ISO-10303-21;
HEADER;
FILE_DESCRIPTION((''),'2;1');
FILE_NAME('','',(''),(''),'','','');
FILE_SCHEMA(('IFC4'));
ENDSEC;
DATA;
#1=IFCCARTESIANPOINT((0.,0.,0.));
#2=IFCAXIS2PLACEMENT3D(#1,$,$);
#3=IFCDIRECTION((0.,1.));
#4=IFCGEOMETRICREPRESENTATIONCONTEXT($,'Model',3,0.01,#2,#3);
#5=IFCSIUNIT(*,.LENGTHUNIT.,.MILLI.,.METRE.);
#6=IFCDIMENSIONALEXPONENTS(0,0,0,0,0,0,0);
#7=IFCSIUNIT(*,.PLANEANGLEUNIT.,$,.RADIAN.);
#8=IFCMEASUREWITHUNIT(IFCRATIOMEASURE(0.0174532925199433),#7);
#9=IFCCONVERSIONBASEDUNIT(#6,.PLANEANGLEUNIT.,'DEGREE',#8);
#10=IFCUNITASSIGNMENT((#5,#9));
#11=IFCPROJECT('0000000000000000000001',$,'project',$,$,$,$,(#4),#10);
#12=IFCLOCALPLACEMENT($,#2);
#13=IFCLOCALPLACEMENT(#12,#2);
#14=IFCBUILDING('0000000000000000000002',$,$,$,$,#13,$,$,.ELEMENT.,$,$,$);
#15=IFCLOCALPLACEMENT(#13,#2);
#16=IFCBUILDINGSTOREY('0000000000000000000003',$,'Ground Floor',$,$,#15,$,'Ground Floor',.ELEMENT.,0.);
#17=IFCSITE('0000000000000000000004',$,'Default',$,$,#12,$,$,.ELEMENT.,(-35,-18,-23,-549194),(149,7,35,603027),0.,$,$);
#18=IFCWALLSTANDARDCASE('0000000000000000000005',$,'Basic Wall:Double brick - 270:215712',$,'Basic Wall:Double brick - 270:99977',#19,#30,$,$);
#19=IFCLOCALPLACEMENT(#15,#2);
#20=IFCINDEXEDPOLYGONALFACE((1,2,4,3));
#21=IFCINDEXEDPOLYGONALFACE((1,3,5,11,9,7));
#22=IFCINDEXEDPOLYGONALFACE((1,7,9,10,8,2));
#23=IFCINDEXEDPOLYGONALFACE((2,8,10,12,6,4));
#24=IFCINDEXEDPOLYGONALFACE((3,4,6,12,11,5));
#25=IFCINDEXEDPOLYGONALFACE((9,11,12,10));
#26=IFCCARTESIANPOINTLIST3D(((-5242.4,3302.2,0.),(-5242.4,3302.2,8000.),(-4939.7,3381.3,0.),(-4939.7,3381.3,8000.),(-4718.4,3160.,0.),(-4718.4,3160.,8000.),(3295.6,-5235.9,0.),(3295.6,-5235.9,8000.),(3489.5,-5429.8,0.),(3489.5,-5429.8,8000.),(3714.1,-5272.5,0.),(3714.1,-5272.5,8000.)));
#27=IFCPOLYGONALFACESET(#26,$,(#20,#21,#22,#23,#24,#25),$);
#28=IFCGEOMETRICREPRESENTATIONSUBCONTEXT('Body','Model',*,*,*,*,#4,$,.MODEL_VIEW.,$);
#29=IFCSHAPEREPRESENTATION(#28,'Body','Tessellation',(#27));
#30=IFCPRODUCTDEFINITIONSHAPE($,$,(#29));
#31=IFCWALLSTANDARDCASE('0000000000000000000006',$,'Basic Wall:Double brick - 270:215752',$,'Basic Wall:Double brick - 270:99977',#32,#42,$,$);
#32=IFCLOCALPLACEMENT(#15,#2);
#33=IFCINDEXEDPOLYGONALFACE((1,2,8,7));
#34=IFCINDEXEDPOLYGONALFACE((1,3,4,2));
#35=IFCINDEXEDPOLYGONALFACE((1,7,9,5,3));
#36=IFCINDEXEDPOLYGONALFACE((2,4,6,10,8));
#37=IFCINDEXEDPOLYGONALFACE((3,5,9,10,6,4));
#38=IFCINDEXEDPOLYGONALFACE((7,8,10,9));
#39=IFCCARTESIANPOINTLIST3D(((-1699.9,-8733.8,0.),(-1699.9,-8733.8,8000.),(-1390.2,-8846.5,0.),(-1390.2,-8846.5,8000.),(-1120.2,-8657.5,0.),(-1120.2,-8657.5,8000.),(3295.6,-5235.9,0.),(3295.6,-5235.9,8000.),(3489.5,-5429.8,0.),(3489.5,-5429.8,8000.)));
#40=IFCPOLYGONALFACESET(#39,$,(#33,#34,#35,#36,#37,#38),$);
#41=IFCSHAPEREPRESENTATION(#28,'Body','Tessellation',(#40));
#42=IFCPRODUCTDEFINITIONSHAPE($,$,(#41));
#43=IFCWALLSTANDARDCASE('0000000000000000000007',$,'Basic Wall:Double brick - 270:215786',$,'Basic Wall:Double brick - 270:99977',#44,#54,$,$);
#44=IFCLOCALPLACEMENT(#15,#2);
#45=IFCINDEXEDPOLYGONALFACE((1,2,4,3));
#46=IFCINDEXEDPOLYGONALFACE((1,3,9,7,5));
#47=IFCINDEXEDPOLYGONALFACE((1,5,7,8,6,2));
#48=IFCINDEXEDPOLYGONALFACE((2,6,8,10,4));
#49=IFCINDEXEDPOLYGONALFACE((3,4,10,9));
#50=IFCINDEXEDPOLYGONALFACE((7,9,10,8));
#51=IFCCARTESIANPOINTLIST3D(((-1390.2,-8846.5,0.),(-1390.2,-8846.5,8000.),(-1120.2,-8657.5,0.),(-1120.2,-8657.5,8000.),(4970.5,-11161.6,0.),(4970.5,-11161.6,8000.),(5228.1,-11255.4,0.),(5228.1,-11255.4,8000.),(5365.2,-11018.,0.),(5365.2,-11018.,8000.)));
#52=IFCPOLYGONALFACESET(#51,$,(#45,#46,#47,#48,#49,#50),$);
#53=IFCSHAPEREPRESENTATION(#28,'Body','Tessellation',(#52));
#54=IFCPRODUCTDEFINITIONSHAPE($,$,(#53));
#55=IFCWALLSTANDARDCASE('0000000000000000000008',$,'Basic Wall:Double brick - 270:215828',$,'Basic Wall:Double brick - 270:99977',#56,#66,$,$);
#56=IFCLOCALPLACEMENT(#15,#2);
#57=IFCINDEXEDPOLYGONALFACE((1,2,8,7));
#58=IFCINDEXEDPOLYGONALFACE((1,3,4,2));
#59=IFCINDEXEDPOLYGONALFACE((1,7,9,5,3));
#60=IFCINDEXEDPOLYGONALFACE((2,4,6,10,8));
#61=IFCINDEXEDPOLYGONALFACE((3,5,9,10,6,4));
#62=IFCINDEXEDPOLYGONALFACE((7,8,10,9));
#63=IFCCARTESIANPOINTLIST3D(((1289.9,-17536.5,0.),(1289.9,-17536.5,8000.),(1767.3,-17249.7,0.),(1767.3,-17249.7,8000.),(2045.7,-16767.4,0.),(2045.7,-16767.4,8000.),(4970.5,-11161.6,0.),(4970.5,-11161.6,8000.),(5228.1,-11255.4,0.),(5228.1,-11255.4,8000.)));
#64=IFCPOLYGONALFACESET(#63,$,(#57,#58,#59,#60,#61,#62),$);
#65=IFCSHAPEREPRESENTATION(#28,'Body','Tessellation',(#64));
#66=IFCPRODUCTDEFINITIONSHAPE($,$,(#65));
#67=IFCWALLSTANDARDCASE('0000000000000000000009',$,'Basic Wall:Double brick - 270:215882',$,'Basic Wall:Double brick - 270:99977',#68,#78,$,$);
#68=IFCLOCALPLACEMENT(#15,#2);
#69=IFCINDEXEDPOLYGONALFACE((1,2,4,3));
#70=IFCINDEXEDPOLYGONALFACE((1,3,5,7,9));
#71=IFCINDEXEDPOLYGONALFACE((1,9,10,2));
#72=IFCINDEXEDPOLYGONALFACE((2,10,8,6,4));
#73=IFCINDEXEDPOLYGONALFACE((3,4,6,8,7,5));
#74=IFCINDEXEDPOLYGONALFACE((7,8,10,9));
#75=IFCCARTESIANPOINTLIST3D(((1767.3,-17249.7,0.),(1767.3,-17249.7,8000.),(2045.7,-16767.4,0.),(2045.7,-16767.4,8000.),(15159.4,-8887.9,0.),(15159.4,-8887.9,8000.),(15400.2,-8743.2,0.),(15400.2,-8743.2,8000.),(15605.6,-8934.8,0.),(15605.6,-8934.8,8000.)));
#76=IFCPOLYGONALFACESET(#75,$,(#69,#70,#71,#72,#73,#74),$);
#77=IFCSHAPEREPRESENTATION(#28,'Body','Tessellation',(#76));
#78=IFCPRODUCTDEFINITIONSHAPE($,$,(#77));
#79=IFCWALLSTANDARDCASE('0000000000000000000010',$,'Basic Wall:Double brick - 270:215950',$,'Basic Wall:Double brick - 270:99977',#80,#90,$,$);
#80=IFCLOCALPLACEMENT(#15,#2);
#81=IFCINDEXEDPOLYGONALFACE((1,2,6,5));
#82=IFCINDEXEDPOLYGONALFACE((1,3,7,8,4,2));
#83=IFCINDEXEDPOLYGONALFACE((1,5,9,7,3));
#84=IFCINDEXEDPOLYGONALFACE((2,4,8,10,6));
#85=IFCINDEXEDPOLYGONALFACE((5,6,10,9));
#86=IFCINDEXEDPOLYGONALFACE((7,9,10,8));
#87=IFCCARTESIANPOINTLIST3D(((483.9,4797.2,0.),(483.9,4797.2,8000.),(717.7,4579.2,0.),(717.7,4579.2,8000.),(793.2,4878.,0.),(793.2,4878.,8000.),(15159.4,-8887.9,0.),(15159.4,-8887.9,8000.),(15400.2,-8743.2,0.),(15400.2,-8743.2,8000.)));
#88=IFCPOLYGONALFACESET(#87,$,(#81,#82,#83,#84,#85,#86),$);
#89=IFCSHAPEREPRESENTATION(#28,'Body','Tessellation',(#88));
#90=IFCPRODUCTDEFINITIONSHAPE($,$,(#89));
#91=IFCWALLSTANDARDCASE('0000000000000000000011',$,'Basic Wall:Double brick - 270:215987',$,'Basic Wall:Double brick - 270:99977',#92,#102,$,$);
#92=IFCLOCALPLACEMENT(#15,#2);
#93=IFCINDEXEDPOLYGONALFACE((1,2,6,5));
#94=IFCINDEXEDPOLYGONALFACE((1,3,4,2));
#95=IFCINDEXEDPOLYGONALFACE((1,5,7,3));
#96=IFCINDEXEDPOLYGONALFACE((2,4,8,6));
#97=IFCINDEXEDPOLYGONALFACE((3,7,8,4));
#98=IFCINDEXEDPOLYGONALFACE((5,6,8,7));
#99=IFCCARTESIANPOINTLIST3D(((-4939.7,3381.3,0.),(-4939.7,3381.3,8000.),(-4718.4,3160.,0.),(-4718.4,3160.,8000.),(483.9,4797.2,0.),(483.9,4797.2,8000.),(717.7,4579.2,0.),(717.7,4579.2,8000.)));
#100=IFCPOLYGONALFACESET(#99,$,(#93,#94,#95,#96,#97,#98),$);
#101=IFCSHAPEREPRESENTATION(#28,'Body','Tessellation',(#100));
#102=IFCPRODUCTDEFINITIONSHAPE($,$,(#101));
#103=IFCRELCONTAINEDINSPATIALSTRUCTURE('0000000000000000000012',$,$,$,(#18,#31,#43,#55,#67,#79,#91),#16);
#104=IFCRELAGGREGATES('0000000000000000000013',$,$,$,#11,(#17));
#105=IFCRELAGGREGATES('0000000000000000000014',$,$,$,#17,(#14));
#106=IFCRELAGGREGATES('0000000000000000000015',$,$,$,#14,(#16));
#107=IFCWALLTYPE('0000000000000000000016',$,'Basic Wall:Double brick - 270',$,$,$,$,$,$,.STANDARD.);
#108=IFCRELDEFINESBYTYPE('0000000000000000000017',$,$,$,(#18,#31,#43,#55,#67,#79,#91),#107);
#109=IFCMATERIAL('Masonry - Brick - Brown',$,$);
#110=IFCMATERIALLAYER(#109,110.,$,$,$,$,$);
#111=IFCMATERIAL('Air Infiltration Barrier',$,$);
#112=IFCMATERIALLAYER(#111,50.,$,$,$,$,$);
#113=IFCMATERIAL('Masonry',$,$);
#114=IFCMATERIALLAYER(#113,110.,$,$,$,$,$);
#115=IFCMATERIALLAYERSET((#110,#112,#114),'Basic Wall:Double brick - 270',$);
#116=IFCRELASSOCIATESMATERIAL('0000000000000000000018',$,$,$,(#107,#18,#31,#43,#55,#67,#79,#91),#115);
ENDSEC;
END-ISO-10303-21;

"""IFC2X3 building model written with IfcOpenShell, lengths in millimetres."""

from ifc_helpers import new_model, entity, si_unit, converted_unit, direction, frame, origin, place, context, subcontext, project, spatial, polyline, outline, extrude, material, layer, layer_set, layer_usage, type_object, element, save


model = new_model("IFC2X3")

# Units and contexts
model_context = context("Model", 3, precision=0.01, world=origin(), true_north=direction((0.0, 1.0)))
body_context = subcontext(model_context, "Body", "Model", "MODEL_VIEW")
ifc_project = project(units=[si_unit("LENGTHUNIT", "METRE", prefix="MILLI"), converted_unit("PLANEANGLEUNIT", "DEGREE", entity("IfcRatioMeasure", 0.0174532925199433), si_unit("PLANEANGLEUNIT", "RADIAN"), dimensions=[0, 0, 0, 0, 0, 0, 0])], contexts=[model_context])

# Site, building, storey
site_placement = place(None, origin())
site = spatial("IfcSite", under=ifc_project, at=site_placement, Name="Default", CompositionType="ELEMENT", RefLatitude=(-35, -18, -23, -549194), RefLongitude=(149, 7, 35, 603027), RefElevation=0.0)
building_placement = place(site_placement, origin())
building = spatial("IfcBuilding", under=site, at=building_placement, CompositionType="ELEMENT")
storey_placement = place(building_placement, origin())
storey = spatial("IfcBuildingStorey", under=building, at=storey_placement, Name="Ground Floor", LongName="Ground Floor", CompositionType="ELEMENT", Elevation=0.0)

# Walls
ifc_material_1 = material(Name="Masonry - Brick - Brown")
ifc_layer_1 = layer(ifc_material_1, 110.0)
ifc_material_2 = material(Name="Air Infiltration Barrier")
ifc_layer_2 = layer(ifc_material_2, 50.0)
ifc_material_3 = material(Name="Masonry")
ifc_layer_3 = layer(ifc_material_3, 110.0)
ifc_layer_set = layer_set([ifc_layer_1, ifc_layer_2, ifc_layer_3], Name="Basic Wall:Double brick - 270")
ifc_layer_usage_1 = layer_usage(ifc_layer_set, "AXIS2", "NEGATIVE", 135.0)
wall_type = type_object("IfcWallType", Name="Basic Wall:Double brick - 270", PredefinedType="STANDARD", material=ifc_layer_set)
wall_1_placement = place(storey_placement, frame((-5147.0, 3397.7, 0.0), z_axis=(0.0, 0.0, 1.0), x_axis=(0.707107, -0.707107, 0.0)))
element("IfcWallStandardCase", 1, at=wall_1_placement, inside=storey, type_object=wall_type, material=ifc_layer_usage_1, Name="Basic Wall:Double brick - 270:215712", ObjectType="Basic Wall:Double brick - 270:99977", context=body_context, shape_type="SweptSolid", body=[
    extrude(outline(polyline([(12348.8, -135.0), (12396.5, 135.0), (471.1, 135.0), (158.2, 135.0), (0.0, -135.0), (12074.7, -135.0), (12348.8, -135.0)])), origin(), (0.0, 0.0, 1.0), 8000.0),
])
ifc_layer_usage_2 = layer_usage(ifc_layer_set, "AXIS2", "NEGATIVE", 135.0)
wall_2_placement = place(storey_placement, frame((3412.1, -5319.2, 0.0), z_axis=(0.0, 0.0, 1.0), x_axis=(-0.819152, -0.573576, 0.0)))
element("IfcWallStandardCase", 2, at=wall_2_placement, inside=storey, type_object=wall_type, material=ifc_layer_usage_2, Name="Basic Wall:Double brick - 270:215752", ObjectType="Basic Wall:Double brick - 270:99977", context=body_context, shape_type="SweptSolid", body=[
    extrude(outline(polyline([(6146.1, -135.0), (5957.0, 135.0), (5627.4, 135.0), (0.0, 135.0), (47.6, -135.0), (6146.1, -135.0)])), origin(), (0.0, 0.0, 1.0), 8000.0),
])
ifc_layer_usage_3 = layer_usage(ifc_layer_set, "AXIS2", "NEGATIVE", 135.0)
wall_3_placement = place(storey_placement, frame((-1344.0, -8719.7, 0.0), z_axis=(0.0, 0.0, 1.0), x_axis=(0.939693, -0.34202, 0.0)))
element("IfcWallStandardCase", 3, at=wall_3_placement, inside=storey, type_object=wall_type, material=ifc_layer_usage_3, Name="Basic Wall:Double brick - 270:215786", ObjectType="Basic Wall:Double brick - 270:99977", context=body_context, shape_type="SweptSolid", body=[
    extrude(outline(polyline([(7043.0, -135.0), (7090.6, 135.0), (189.1, 135.0), (0.0, -135.0), (6768.8, -135.0), (7043.0, -135.0)])), origin(), (0.0, 0.0, 1.0), 8000.0),
])
ifc_layer_usage_4 = layer_usage(ifc_layer_set, "AXIS2", "NEGATIVE", 135.0)
wall_4_placement = place(storey_placement, frame((5111.2, -11187.9, 0.0), z_axis=(0.0, 0.0, 1.0), x_axis=(-0.5, -0.866025, 0.0)))
element("IfcWallStandardCase", 4, at=wall_4_placement, inside=storey, type_object=wall_type, material=ifc_layer_usage_4, Name="Basic Wall:Double brick - 270:215828", ObjectType="Basic Wall:Double brick - 270:99977", context=body_context, shape_type="SweptSolid", body=[
    extrude(outline(polyline([(7408.7, -135.0), (6921.6, 135.0), (6364.7, 135.0), (0.0, 135.0), (47.6, -135.0), (7408.7, -135.0)])), origin(), (0.0, 0.0, 1.0), 8000.0),
])
ifc_layer_usage_5 = layer_usage(ifc_layer_set, "AXIS2", "NEGATIVE", 135.0)
wall_5_placement = place(storey_placement, frame((1697.7, -17134.0, 0.0), z_axis=(0.0, 0.0, 1.0), x_axis=(0.857167, 0.515038, 0.0)))
element("IfcWallStandardCase", 5, at=wall_5_placement, inside=storey, type_object=wall_type, material=ifc_layer_usage_5, Name="Basic Wall:Double brick - 270:215882", ObjectType="Basic Wall:Double brick - 270:99977", context=body_context, shape_type="SweptSolid", body=[
    extrude(outline(polyline([(16144.2, -135.0), (16066.8, 135.0), (15785.9, 135.0), (487.1, 135.0), (0.0, -135.0), (16144.2, -135.0)])), origin(), (0.0, 0.0, 1.0), 8000.0),
])
ifc_layer_usage_6 = layer_usage(ifc_layer_set, "AXIS2", "NEGATIVE", 135.0)
wall_6_placement = place(storey_placement, frame((15308.1, -8842.0, 0.0), z_axis=(0.0, 0.0, 1.0), x_axis=(-0.731354, 0.681998, 0.0)))
element("IfcWallStandardCase", 6, at=wall_6_placement, inside=storey, type_object=wall_type, material=ifc_layer_usage_6, Name="Basic Wall:Double brick - 270:215950", ObjectType="Basic Wall:Double brick - 270:99977", context=body_context, shape_type="SweptSolid", body=[
    extrude(outline(polyline([(19972.5, -135.0), (20143.7, 135.0), (19824.0, 135.0), (77.4, 135.0), (0.0, -135.0), (19972.5, -135.0)])), origin(), (0.0, 0.0, 1.0), 8000.0),
])
ifc_layer_usage_7 = layer_usage(ifc_layer_set, "AXIS2", "NEGATIVE", 135.0)
wall_7_placement = place(storey_placement, frame((683.6, 4709.8, 0.0), z_axis=(0.0, 0.0, 1.0), x_axis=(-0.967567, -0.252614, 0.0)))
element("IfcWallStandardCase", 7, at=wall_7_placement, inside=storey, type_object=wall_type, material=ifc_layer_usage_7, Name="Basic Wall:Double brick - 270:215987", ObjectType="Basic Wall:Double brick - 270:99977", context=body_context, shape_type="SweptSolid", body=[
    extrude(outline(polyline([(5776.5, -135.0), (5618.2, 135.0), (0.0, 135.0), (171.1, -135.0), (5776.5, -135.0)])), origin(), (0.0, 0.0, 1.0), 8000.0),
])

save(model, "model.ifc")
